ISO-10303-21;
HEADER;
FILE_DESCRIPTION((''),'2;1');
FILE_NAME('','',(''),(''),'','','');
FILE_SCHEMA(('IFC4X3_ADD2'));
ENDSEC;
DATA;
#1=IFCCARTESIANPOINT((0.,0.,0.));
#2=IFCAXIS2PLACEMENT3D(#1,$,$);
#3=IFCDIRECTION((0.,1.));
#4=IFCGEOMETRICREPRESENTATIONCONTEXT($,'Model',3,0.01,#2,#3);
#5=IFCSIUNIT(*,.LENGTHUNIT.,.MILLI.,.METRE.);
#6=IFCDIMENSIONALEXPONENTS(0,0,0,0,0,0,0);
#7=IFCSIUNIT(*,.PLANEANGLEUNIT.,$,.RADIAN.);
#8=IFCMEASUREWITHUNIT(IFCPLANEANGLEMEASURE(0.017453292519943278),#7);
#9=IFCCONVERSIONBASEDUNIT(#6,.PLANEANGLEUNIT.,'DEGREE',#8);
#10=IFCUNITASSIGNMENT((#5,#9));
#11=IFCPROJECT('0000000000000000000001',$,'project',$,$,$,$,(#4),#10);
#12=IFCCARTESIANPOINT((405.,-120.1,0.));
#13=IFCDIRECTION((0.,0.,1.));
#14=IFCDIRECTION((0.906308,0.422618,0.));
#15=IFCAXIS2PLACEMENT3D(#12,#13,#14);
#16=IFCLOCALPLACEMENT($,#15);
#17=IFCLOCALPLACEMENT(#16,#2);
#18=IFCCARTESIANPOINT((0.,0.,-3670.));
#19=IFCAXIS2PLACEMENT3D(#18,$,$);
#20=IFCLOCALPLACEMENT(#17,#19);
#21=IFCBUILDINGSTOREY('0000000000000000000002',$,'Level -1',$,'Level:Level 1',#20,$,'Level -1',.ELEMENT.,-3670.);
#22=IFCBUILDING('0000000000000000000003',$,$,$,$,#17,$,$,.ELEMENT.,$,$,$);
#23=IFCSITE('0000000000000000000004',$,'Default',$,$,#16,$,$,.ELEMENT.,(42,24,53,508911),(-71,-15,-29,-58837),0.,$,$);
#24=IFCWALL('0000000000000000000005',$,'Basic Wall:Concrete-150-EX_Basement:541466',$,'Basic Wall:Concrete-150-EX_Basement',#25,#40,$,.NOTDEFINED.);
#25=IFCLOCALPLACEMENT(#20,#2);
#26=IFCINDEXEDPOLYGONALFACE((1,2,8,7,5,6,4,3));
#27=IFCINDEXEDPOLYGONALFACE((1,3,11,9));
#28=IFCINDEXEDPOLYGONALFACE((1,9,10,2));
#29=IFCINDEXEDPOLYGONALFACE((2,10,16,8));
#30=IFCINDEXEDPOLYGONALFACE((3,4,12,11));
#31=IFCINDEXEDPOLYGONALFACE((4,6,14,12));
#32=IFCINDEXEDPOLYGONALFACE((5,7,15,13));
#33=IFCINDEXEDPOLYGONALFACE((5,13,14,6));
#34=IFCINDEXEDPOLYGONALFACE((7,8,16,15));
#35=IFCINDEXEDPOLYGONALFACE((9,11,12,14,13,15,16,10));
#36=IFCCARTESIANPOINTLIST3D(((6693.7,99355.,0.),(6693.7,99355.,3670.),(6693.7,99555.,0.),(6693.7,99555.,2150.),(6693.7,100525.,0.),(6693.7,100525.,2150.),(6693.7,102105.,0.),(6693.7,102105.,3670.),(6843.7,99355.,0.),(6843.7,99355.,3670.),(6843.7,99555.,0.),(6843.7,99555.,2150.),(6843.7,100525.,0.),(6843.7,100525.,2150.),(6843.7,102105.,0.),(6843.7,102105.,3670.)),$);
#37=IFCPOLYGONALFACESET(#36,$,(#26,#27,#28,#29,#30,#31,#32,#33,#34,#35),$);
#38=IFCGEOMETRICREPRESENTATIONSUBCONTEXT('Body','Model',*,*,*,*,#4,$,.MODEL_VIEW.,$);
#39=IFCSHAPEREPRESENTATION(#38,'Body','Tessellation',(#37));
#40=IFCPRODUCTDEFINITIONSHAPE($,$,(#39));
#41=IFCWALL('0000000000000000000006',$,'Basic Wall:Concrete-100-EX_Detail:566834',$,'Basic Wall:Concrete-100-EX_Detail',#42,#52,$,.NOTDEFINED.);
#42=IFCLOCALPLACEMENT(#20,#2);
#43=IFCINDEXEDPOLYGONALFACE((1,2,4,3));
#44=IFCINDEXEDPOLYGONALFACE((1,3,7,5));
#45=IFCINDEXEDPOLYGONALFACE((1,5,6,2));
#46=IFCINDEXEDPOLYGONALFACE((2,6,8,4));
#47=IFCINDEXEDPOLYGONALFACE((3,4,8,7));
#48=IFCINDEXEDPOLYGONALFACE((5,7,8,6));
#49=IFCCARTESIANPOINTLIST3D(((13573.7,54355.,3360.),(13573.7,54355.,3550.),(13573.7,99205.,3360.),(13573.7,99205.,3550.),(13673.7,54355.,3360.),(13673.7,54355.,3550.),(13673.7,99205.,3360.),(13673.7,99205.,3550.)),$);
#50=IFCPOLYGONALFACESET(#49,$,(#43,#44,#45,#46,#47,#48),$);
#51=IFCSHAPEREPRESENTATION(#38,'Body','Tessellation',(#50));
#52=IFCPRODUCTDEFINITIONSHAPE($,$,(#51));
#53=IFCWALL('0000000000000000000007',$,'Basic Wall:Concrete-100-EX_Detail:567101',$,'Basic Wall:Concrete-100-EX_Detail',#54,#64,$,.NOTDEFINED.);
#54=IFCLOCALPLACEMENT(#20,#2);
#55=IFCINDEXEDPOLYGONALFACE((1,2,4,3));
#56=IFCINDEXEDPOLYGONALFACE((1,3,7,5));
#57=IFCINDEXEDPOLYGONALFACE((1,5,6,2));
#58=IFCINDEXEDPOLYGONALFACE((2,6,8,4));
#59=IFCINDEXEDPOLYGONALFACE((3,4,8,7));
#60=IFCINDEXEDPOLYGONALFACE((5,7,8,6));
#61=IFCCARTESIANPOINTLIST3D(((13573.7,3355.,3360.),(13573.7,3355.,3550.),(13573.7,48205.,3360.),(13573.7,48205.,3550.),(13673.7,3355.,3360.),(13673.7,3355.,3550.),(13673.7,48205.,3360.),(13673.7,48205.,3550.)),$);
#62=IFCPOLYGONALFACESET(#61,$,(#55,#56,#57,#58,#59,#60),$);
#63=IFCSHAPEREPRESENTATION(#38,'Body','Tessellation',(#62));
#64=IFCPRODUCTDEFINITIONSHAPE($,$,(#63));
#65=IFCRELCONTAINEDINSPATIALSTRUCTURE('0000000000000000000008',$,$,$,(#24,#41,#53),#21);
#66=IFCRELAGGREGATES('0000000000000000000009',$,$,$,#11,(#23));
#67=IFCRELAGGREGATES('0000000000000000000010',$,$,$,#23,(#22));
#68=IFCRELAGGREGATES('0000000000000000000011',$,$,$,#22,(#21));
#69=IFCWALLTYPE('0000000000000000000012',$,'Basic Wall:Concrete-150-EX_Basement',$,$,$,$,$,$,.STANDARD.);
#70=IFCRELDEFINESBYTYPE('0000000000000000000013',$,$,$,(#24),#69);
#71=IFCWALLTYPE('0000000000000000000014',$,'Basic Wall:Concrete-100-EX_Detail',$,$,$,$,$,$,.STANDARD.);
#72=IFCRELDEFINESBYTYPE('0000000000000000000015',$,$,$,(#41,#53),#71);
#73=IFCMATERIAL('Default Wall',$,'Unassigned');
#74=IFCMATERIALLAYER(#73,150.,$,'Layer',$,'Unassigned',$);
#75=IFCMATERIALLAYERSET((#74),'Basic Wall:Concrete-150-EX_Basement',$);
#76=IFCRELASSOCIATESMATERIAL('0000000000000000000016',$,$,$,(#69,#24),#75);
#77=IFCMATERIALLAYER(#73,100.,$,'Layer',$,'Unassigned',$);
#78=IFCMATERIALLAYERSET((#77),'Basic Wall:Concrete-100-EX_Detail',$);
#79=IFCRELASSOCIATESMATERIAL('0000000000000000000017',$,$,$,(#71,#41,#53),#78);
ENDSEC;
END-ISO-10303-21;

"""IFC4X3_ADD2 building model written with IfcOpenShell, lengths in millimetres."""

from ifc_helpers import new_model, entity, si_unit, converted_unit, direction, frame, frame_2d, origin, place, context, subcontext, project, spatial, rectangle, extrude, material, layer, layer_set, type_object, element, save


model = new_model("IFC4X3_ADD2")

# Units and contexts
model_context = context("Model", 3, precision=0.01, world=origin(), true_north=direction((0.0, 1.0)))
body_context = subcontext(model_context, "Body", "Model", "MODEL_VIEW")
ifc_project = project(units=[si_unit("LENGTHUNIT", "METRE", prefix="MILLI"), converted_unit("PLANEANGLEUNIT", "DEGREE", entity("IfcPlaneAngleMeasure", 0.017453292519943278), si_unit("PLANEANGLEUNIT", "RADIAN"), dimensions=[0, 0, 0, 0, 0, 0, 0])], contexts=[model_context])

# Site, building, storey
site_placement = place(None, frame((405.0, -120.1, 0.0), z_axis=(0.0, 0.0, 1.0), x_axis=(0.906308, 0.422618, 0.0)))
site = spatial("IfcSite", under=ifc_project, at=site_placement, Name="Default", CompositionType="ELEMENT", RefLatitude=(42, 24, 53, 508911), RefLongitude=(-71, -15, -29, -58837), RefElevation=0.0)
building_placement = place(site_placement, origin())
building = spatial("IfcBuilding", under=site, at=building_placement, CompositionType="ELEMENT")
storey_placement = place(building_placement, frame((0.0, 0.0, -3670.0)))
storey = spatial("IfcBuildingStorey", under=building, at=storey_placement, Name="Level -1", ObjectType="Level:Level 1", LongName="Level -1", CompositionType="ELEMENT", Elevation=-3670.0)

# Shared definitions
ifc_material = material(Name="Default Wall", Category="Unassigned")

# Wall, opening
ifc_layer_1 = layer(ifc_material, 150.0, Name="Layer", Category="Unassigned")
ifc_layer_set_1 = layer_set([ifc_layer_1], Name="Basic Wall:Concrete-150-EX_Basement")
wall_type_1 = type_object("IfcWallType", Name="Basic Wall:Concrete-150-EX_Basement", PredefinedType="STANDARD", material=ifc_layer_set_1)
wall_1_placement = place(storey_placement, frame((6768.7, 99355.0, 0.0), z_axis=(0.0, 0.0, 1.0), x_axis=(0.0, 1.0, 0.0)))
wall_1 = element("IfcWall", 1, at=wall_1_placement, inside=storey, type_object=wall_type_1, material=ifc_layer_set_1, Name="Basic Wall:Concrete-150-EX_Basement:541466", ObjectType="Basic Wall:Concrete-150-EX_Basement", PredefinedType="NOTDEFINED", context=body_context, shape_type="SweptSolid", body=[
    extrude(rectangle(XDim=2750.0, YDim=150.0, at=frame_2d((1375.0, 0.0), x_axis=(-1.0, 0.0))), origin(), (0.0, 0.0, 1.0), 3670.0),
])
opening_1_placement = place(wall_1_placement, origin())
element("IfcOpeningElement", 2, at=opening_1_placement, cuts=wall_1, PredefinedType="OPENING", context=body_context, shape_type="SweptSolid", body=[
    extrude(rectangle(XDim=2150.0, YDim=970.0, at=frame_2d((0.0, 0.0), x_axis=(0.0, 1.0))), frame((685.0, 75.0, 1075.0), z_axis=(0.0, -1.0, 0.0), x_axis=(1.0, 0.0, 0.0)), (0.0, 0.0, 1.0), 150.0),
])

# Walls
ifc_layer_2 = layer(ifc_material, 100.0, Name="Layer", Category="Unassigned")
ifc_layer_set_2 = layer_set([ifc_layer_2], Name="Basic Wall:Concrete-100-EX_Detail")
wall_type_2 = type_object("IfcWallType", Name="Basic Wall:Concrete-100-EX_Detail", PredefinedType="STANDARD", material=ifc_layer_set_2)
wall_2_placement = place(storey_placement, frame((13623.7, 99205.0, 3360.0), z_axis=(0.0, 0.0, 1.0), x_axis=(0.0, -1.0, 0.0)))
element("IfcWall", 3, at=wall_2_placement, inside=storey, type_object=wall_type_2, material=ifc_layer_set_2, Name="Basic Wall:Concrete-100-EX_Detail:566834", ObjectType="Basic Wall:Concrete-100-EX_Detail", PredefinedType="NOTDEFINED", context=body_context, shape_type="SweptSolid", body=[
    extrude(rectangle(XDim=44850.0, YDim=100.0, at=frame_2d((22425.0, 0.0), x_axis=(-1.0, 0.0))), origin(), (0.0, 0.0, 1.0), 190.0),
])
wall_3_placement = place(storey_placement, frame((13623.7, 48205.0, 3360.0), z_axis=(0.0, 0.0, 1.0), x_axis=(0.0, -1.0, 0.0)))
element("IfcWall", 4, at=wall_3_placement, inside=storey, type_object=wall_type_2, material=ifc_layer_set_2, Name="Basic Wall:Concrete-100-EX_Detail:567101", ObjectType="Basic Wall:Concrete-100-EX_Detail", PredefinedType="NOTDEFINED", context=body_context, shape_type="SweptSolid", body=[
    extrude(rectangle(XDim=44850.0, YDim=100.0, at=frame_2d((22425.0, 0.0), x_axis=(-1.0, 0.0))), origin(), (0.0, 0.0, 1.0), 190.0),
])

save(model, "model.ifc")
